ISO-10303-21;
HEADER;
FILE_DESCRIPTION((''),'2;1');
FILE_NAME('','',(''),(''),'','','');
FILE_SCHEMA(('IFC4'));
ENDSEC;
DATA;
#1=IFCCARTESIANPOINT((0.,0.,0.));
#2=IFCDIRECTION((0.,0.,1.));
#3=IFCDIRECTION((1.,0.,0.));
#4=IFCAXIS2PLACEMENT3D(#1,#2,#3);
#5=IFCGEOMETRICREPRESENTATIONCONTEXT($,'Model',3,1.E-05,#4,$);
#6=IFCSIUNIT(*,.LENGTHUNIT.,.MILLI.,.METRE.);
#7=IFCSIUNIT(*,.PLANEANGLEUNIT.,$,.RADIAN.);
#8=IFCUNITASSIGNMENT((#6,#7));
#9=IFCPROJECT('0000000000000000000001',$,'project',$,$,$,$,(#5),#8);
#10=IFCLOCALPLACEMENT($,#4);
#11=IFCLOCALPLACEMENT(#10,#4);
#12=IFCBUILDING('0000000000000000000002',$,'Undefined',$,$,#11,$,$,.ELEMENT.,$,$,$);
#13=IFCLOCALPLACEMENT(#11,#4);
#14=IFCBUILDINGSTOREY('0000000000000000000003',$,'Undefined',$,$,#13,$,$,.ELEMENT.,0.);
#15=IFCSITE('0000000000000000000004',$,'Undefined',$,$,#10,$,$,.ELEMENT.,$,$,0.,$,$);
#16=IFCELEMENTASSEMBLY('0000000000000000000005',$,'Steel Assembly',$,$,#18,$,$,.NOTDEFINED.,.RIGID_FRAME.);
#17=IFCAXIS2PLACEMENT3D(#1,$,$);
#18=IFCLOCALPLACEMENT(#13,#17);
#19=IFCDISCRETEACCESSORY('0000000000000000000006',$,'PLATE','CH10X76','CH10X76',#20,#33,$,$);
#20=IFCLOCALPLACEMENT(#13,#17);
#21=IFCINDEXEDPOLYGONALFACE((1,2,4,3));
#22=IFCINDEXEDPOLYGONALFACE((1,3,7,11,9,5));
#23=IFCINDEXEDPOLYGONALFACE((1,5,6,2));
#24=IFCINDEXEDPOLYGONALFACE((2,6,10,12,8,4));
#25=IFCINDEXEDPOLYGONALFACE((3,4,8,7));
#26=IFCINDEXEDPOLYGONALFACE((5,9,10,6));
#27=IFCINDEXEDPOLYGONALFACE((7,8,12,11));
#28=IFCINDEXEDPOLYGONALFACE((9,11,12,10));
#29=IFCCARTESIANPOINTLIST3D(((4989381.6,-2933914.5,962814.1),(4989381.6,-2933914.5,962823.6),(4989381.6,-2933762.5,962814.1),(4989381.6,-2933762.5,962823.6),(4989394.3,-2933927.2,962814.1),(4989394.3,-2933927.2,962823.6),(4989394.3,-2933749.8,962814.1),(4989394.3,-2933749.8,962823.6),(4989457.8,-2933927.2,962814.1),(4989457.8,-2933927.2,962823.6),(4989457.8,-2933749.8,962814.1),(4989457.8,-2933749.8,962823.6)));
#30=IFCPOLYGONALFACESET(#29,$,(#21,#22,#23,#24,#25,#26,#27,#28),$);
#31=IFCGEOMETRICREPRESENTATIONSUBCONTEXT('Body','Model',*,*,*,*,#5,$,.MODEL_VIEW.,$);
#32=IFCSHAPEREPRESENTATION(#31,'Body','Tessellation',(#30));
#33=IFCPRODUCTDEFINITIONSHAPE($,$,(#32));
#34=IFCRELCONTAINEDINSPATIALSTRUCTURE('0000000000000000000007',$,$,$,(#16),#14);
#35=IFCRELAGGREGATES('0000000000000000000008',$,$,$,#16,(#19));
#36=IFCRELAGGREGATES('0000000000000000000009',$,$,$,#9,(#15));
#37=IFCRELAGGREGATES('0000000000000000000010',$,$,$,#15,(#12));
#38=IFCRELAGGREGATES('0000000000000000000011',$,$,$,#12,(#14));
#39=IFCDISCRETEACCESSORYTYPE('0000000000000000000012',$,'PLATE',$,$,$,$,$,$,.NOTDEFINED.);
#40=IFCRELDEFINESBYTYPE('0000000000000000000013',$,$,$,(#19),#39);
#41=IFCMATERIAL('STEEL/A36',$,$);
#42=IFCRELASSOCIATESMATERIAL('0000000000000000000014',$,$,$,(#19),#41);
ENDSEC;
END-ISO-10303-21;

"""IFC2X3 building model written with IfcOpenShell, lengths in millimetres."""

from ifc_helpers import new_model, si_unit, frame, origin_with_axes, place, context, subcontext, project, spatial, polyline, outline, extrude, boolean, material, type_object, element, aggregate, save


model = new_model("IFC2X3")

# Units and contexts
model_context = context("Model", 3, precision=1e-05, world=origin_with_axes())
body_context = subcontext(model_context, "Body", "Model", "MODEL_VIEW")
ifc_project = project(units=[si_unit("LENGTHUNIT", "METRE", prefix="MILLI"), si_unit("PLANEANGLEUNIT", "RADIAN")], contexts=[model_context])

# Site, building, storey
site_placement = place(None, origin_with_axes())
site = spatial("IfcSite", under=ifc_project, at=site_placement, Name="Undefined", CompositionType="ELEMENT", RefElevation=0.0)
building_placement = place(site_placement, origin_with_axes())
building = spatial("IfcBuilding", under=site, at=building_placement, Name="Undefined", CompositionType="ELEMENT")
storey_placement = place(building_placement, origin_with_axes())
storey = spatial("IfcBuildingStorey", under=building, at=storey_placement, Name="Undefined", CompositionType="ELEMENT", Elevation=0.0)

# Shared definitions
ifc_material_1 = material(Name="STEEL/A36")

# Element assembly
assembly_1_placement = place(storey_placement, origin_with_axes())
assembly_1 = element("IfcElementAssembly", 1, at=assembly_1_placement, inside=storey, Name="Steel Assembly", AssemblyPlace="NOTDEFINED", PredefinedType="RIGID_FRAME")

# Discrete accessory
discrete_accessory_type_1 = type_object("IfcDiscreteAccessoryType", Name="PLATE")
discrete_accessory_1_placement = place(assembly_1_placement, frame((4989381.6, -2933927.2, 962818.9), z_axis=(0.0, 0.0, 1.0), x_axis=(1.0, 0.0, 0.0)))
discrete_accessory_1 = element("IfcDiscreteAccessory", 2, at=discrete_accessory_1_placement, type_object=discrete_accessory_type_1, material=ifc_material_1, Name="PLATE", Description="CH10X76", ObjectType="CH10X76", context=body_context, shape_type="CSG", body=[
    boolean("DIFFERENCE", boolean("DIFFERENCE", extrude(outline(polyline([(0.0, 0.0), (76.2, 0.0), (76.2, 177.4), (0.0, 177.4), (0.0, 0.0)])), frame((0.0, 0.0, -4.8), z_axis=(0.0, 0.0, 1.0), x_axis=(1.0, 0.0, 0.0)), (0.0, 0.0, 1.0), 9.5), extrude(outline(polyline([(0.0, 0.0), (18.0, 0.0), (9.0, 9.0), (0.0, 0.0)])), frame((0.0, 164.7, -4.8), z_axis=(0.0, 0.0, 1.0), x_axis=(0.707107, 0.707107, 0.0)), (0.0, 0.0, 1.0), 15.0)), extrude(outline(polyline([(0.0, 0.0), (12.7, 0.0), (0.0, 12.7), (0.0, 0.0)])), frame((0.0, 0.0, -4.8), z_axis=(0.0, 0.0, 1.0), x_axis=(1.0, 0.0, 0.0)), (0.0, 0.0, 1.0), 15.0)),
])
aggregate(assembly_1, [discrete_accessory_1])

save(model, "model.ifc")
